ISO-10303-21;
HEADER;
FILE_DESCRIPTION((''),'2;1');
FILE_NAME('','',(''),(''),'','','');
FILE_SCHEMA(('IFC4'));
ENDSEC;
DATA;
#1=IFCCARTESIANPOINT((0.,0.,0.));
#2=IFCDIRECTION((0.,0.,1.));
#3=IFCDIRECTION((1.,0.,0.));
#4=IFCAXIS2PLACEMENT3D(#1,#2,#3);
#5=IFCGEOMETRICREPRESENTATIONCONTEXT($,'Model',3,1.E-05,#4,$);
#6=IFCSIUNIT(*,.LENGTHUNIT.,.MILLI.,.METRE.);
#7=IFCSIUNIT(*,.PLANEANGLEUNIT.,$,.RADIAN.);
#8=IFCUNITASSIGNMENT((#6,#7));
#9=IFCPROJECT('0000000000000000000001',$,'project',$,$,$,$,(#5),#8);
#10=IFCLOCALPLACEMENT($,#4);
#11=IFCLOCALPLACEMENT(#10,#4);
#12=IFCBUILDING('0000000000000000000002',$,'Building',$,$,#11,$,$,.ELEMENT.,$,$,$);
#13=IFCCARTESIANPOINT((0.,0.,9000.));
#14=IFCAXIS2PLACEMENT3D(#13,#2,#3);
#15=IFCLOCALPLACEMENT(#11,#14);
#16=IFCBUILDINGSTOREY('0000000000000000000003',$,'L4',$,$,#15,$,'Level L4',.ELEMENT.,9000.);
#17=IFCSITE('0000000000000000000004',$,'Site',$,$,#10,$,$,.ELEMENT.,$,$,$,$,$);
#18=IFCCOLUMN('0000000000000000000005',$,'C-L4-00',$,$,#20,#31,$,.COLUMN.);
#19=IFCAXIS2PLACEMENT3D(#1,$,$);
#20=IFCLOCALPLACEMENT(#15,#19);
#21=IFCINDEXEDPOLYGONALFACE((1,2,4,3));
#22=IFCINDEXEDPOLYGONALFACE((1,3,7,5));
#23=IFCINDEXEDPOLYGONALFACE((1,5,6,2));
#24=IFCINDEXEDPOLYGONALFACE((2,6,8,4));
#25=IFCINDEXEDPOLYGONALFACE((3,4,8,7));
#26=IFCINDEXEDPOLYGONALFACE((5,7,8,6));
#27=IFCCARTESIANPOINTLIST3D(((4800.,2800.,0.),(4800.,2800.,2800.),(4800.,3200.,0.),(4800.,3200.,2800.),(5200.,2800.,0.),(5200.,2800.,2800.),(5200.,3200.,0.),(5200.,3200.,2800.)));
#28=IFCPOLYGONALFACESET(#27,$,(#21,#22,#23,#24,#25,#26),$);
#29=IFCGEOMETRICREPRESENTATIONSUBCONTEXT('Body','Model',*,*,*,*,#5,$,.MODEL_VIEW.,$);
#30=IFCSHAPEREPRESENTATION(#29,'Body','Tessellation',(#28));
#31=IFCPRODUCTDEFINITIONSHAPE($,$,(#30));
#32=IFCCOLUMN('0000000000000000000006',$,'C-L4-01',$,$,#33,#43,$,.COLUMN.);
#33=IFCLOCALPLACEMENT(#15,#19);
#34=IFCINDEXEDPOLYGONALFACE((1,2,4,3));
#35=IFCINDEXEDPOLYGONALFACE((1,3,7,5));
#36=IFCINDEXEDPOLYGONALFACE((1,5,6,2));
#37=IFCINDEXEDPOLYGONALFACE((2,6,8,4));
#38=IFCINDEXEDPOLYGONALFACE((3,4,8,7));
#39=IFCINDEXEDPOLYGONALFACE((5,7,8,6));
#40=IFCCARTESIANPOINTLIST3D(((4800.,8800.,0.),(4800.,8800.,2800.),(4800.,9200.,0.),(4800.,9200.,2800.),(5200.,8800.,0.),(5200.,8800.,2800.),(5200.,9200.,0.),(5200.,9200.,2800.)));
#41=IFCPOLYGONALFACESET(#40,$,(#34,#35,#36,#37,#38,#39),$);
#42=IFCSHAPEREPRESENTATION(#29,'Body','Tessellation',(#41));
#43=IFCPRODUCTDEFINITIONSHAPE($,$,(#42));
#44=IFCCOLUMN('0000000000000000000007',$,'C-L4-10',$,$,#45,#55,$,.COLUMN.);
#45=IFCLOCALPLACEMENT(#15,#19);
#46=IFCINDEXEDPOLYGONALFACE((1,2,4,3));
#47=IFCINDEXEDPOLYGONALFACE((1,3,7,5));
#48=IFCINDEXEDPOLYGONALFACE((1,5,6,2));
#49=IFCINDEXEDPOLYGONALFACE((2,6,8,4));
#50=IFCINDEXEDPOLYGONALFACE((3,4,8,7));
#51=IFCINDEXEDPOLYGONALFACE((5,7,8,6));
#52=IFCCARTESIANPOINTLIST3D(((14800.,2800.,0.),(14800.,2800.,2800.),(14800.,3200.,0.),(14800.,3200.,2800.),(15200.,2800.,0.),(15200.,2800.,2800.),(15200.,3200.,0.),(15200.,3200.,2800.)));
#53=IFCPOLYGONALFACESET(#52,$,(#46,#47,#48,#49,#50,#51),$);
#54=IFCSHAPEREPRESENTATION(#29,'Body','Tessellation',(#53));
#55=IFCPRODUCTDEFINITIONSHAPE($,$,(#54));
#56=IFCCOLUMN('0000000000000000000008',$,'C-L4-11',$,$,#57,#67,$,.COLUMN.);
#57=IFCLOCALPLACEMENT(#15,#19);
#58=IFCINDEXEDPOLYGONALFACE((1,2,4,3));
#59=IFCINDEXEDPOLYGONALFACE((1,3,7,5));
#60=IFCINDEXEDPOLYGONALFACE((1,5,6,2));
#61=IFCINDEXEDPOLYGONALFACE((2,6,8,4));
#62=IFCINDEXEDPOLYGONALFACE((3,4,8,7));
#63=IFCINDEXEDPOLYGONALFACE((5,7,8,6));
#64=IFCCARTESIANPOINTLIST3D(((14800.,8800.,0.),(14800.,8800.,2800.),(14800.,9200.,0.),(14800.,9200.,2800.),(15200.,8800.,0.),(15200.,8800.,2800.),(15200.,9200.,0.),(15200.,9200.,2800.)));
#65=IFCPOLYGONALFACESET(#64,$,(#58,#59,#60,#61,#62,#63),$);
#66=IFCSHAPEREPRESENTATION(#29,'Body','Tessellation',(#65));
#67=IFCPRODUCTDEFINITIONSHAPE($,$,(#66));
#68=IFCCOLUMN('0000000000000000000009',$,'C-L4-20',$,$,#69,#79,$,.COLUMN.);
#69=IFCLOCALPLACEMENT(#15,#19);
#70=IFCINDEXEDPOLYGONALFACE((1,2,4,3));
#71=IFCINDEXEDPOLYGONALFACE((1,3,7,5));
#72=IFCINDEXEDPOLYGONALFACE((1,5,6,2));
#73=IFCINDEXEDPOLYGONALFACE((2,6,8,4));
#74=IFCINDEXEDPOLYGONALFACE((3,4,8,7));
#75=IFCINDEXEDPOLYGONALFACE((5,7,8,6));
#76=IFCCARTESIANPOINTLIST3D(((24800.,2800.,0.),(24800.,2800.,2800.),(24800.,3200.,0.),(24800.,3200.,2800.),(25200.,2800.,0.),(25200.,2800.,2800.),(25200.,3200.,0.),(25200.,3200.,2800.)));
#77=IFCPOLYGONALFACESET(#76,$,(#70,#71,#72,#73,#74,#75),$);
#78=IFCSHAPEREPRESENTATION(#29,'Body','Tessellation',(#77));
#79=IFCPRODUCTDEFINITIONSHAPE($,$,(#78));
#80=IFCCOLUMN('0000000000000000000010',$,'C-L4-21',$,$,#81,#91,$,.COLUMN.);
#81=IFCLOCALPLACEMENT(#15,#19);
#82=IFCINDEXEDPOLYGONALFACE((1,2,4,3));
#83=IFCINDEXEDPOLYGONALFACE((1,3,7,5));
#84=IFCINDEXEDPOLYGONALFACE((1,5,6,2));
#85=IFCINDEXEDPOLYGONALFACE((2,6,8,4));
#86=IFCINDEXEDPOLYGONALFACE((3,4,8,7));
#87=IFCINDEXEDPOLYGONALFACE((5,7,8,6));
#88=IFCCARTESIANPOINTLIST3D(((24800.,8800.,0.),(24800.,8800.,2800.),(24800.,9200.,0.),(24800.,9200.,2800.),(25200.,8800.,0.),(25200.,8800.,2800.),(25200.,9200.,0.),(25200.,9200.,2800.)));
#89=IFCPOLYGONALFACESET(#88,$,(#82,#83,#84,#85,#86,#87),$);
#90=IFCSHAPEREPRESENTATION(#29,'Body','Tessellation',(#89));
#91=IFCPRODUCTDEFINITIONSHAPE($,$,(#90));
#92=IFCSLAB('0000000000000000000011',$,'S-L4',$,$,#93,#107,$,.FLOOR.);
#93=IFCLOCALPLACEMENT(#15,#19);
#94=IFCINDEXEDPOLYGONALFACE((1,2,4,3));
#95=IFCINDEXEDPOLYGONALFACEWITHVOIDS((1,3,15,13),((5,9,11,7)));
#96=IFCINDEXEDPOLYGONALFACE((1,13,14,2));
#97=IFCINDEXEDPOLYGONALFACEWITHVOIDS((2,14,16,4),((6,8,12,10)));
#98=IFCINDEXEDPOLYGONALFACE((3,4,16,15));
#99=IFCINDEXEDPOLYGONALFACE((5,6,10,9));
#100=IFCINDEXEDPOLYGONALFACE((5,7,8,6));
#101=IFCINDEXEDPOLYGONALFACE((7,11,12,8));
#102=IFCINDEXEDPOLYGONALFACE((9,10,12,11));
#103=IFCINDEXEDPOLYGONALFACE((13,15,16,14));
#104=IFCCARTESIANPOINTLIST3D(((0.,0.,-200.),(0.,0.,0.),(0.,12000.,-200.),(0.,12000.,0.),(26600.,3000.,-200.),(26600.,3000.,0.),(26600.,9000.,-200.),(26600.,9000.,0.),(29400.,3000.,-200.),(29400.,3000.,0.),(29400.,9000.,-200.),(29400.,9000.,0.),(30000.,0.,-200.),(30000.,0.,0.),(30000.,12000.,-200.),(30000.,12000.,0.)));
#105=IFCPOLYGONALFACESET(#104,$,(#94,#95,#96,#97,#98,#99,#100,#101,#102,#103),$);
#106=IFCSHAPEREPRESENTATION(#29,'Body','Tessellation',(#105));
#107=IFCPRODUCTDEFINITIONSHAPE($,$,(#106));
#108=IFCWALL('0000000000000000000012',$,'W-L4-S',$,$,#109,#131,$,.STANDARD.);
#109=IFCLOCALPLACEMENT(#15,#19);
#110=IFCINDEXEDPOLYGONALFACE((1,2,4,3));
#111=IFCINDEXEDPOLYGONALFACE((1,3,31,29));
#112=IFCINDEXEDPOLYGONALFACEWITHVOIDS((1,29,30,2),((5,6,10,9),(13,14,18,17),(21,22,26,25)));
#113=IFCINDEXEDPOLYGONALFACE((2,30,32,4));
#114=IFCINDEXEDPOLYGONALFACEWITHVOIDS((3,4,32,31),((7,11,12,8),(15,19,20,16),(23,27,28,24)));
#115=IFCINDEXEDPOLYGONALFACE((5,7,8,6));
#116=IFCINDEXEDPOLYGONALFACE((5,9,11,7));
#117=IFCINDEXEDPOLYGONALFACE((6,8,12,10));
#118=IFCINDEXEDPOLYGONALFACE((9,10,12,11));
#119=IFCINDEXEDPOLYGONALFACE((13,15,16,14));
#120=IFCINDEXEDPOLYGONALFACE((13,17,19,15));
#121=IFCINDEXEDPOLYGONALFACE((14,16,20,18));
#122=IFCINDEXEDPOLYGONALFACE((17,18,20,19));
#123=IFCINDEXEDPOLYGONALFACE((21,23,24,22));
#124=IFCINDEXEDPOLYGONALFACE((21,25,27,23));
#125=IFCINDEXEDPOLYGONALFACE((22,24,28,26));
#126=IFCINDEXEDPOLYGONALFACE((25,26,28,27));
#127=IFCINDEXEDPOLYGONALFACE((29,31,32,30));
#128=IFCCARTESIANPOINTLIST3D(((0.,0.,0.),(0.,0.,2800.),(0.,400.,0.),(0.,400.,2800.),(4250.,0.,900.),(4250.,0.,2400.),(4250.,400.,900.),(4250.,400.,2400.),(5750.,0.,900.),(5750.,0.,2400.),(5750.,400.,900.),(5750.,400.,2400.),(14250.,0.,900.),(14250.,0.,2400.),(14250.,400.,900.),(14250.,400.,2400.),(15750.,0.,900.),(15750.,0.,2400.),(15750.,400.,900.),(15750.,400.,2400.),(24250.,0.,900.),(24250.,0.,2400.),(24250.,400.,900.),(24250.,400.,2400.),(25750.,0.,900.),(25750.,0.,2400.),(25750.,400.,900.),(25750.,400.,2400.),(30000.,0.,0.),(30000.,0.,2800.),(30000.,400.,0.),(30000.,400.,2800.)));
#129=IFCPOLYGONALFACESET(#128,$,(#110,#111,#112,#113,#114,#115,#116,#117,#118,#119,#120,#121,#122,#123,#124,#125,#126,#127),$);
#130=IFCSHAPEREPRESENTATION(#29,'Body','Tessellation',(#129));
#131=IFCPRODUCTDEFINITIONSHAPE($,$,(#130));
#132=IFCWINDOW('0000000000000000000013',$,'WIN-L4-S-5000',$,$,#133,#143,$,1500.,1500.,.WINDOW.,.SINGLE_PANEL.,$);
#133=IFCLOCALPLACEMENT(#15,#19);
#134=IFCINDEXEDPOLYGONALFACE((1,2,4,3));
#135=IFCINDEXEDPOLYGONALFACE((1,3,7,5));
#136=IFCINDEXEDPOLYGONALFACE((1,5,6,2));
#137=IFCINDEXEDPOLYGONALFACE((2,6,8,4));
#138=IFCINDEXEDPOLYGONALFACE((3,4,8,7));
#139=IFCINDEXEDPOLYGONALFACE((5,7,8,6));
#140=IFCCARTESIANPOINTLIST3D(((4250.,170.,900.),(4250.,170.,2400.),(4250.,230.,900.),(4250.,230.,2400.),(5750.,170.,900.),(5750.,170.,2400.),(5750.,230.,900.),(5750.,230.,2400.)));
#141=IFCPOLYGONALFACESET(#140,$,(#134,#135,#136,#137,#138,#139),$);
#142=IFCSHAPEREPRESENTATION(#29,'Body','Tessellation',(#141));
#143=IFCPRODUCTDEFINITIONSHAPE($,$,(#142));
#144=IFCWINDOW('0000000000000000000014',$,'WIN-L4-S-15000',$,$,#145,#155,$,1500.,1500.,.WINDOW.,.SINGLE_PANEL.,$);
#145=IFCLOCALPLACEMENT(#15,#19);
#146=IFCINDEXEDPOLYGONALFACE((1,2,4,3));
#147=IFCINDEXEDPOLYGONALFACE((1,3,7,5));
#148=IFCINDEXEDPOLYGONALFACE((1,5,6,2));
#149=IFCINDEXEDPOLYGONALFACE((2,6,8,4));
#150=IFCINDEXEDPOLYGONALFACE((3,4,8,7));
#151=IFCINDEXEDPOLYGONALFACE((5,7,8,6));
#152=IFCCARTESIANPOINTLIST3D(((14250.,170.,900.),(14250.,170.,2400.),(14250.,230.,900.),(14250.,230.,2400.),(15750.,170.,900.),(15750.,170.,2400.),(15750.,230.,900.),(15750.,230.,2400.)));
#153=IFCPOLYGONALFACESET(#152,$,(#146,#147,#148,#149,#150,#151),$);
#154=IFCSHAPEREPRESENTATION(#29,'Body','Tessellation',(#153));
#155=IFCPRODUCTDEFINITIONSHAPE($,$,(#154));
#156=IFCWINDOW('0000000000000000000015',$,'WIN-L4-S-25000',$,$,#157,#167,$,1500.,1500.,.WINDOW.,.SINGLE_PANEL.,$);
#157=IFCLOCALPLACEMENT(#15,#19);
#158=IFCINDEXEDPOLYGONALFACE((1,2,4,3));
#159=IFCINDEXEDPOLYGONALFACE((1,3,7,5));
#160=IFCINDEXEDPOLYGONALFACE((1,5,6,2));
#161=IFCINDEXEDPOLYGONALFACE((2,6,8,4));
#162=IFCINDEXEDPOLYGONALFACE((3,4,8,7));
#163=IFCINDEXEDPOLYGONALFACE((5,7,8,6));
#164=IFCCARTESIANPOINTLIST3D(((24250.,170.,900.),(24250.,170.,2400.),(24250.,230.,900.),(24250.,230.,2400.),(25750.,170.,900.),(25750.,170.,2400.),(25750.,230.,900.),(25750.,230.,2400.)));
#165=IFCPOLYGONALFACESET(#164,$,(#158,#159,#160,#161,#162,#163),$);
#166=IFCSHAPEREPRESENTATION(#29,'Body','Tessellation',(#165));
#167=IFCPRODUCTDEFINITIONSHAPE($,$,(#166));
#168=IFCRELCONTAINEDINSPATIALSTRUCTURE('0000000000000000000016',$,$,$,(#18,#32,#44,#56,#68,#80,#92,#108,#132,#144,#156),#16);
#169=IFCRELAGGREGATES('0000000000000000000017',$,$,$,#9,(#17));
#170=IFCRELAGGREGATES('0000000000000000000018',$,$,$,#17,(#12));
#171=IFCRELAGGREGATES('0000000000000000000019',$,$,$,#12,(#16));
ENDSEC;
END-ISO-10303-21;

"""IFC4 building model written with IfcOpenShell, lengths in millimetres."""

from ifc_helpers import new_model, si_unit, frame, origin_with_axes, origin_2d, place, context, subcontext, project, spatial, rectangle, extrude, element, fill, save


model = new_model("IFC4")

# Units and contexts
model_context = context("Model", 3, precision=1e-05, world=origin_with_axes())
body_context = subcontext(model_context, "Body", "Model", "MODEL_VIEW")
ifc_project = project(units=[si_unit("LENGTHUNIT", "METRE", prefix="MILLI"), si_unit("PLANEANGLEUNIT", "RADIAN")], contexts=[model_context])

# Site, building, storey
site_placement = place(None, origin_with_axes())
site = spatial("IfcSite", under=ifc_project, at=site_placement, Name="Site", CompositionType="ELEMENT")
building_placement = place(site_placement, origin_with_axes())
building = spatial("IfcBuilding", under=site, at=building_placement, Name="Building", CompositionType="ELEMENT")
storey_placement = place(building_placement, frame((0.0, 0.0, 9000.0), z_axis=(0.0, 0.0, 1.0), x_axis=(1.0, 0.0, 0.0)))
storey = spatial("IfcBuildingStorey", under=building, at=storey_placement, Name="L4", LongName="Level L4", CompositionType="ELEMENT", Elevation=9000.0)

# Columns
for number, where, z_axis, x_axis, name in (
    (1, (5000.0, 3000.0, 0.0), (0.0, 0.0, 1.0), (1.0, 0.0, 0.0), "C-L4-00"),
    (2, (5000.0, 9000.0, 0.0), (0.0, 0.0, 1.0), (1.0, 0.0, 0.0), "C-L4-01"),
    (3, (15000.0, 3000.0, 0.0), (0.0, 0.0, 1.0), (1.0, 0.0, 0.0), "C-L4-10"),
    (4, (15000.0, 9000.0, 0.0), (0.0, 0.0, 1.0), (1.0, 0.0, 0.0), "C-L4-11"),
    (5, (25000.0, 3000.0, 0.0), (0.0, 0.0, 1.0), (1.0, 0.0, 0.0), "C-L4-20"),
    (6, (25000.0, 9000.0, 0.0), (0.0, 0.0, 1.0), (1.0, 0.0, 0.0), "C-L4-21"),
):
    element("IfcColumn", number, at=place(storey_placement, frame(where, z_axis=z_axis, x_axis=x_axis)), inside=storey, Name=name, PredefinedType="COLUMN", context=body_context, shape_type="SweptSolid", body=[
        extrude(rectangle(XDim=400.0, YDim=400.0, at=origin_2d()), origin_with_axes(), (0.0, 0.0, 1.0), 2800.0),
    ])

# Slab, opening
slab_placement = place(storey_placement, frame((15000.0, 6000.0, -200.0), z_axis=(0.0, 0.0, 1.0), x_axis=(1.0, 0.0, 0.0)))
slab = element("IfcSlab", 7, at=slab_placement, inside=storey, Name="S-L4", PredefinedType="FLOOR", context=body_context, shape_type="SweptSolid", body=[
    extrude(rectangle(XDim=30000.0, YDim=12000.0, at=origin_2d()), origin_with_axes(), (0.0, 0.0, 1.0), 200.0),
])
opening_1_placement = place(slab_placement, frame((13000.0, 0.0, -50.0), z_axis=(0.0, 0.0, 1.0), x_axis=(1.0, 0.0, 0.0)))
element("IfcOpeningElement", 8, at=opening_1_placement, cuts=slab, PredefinedType="OPENING", context=body_context, shape_type="SweptSolid", body=[
    extrude(rectangle(XDim=2800.0, YDim=6000.0, at=origin_2d()), origin_with_axes(), (0.0, 0.0, 1.0), 300.0),
])

# Wall, openings, windows
wall_1_placement = place(storey_placement, frame((15000.0, 200.0, 0.0), z_axis=(0.0, 0.0, 1.0), x_axis=(1.0, 0.0, 0.0)))
wall_1 = element("IfcWall", 9, at=wall_1_placement, inside=storey, Name="W-L4-S", PredefinedType="STANDARD", context=body_context, shape_type="SweptSolid", body=[
    extrude(rectangle(XDim=30000.0, YDim=400.0, at=origin_2d()), origin_with_axes(), (0.0, 0.0, 1.0), 2800.0),
])
opening_2_placement = place(wall_1_placement, frame((-10000.0, 0.0, 900.0), z_axis=(0.0, 0.0, 1.0), x_axis=(1.0, 0.0, 0.0)))
opening_2 = element("IfcOpeningElement", 10, at=opening_2_placement, cuts=wall_1, PredefinedType="OPENING", context=body_context, shape_type="SweptSolid", body=[
    extrude(rectangle(XDim=1500.0, YDim=500.0, at=origin_2d()), origin_with_axes(), (0.0, 0.0, 1.0), 1500.0),
])
opening_3_placement = place(wall_1_placement, frame((0.0, 0.0, 900.0), z_axis=(0.0, 0.0, 1.0), x_axis=(1.0, 0.0, 0.0)))
opening_3 = element("IfcOpeningElement", 11, at=opening_3_placement, cuts=wall_1, PredefinedType="OPENING", context=body_context, shape_type="SweptSolid", body=[
    extrude(rectangle(XDim=1500.0, YDim=500.0, at=origin_2d()), origin_with_axes(), (0.0, 0.0, 1.0), 1500.0),
])
opening_4_placement = place(wall_1_placement, frame((10000.0, 0.0, 900.0), z_axis=(0.0, 0.0, 1.0), x_axis=(1.0, 0.0, 0.0)))
opening_4 = element("IfcOpeningElement", 12, at=opening_4_placement, cuts=wall_1, PredefinedType="OPENING", context=body_context, shape_type="SweptSolid", body=[
    extrude(rectangle(XDim=1500.0, YDim=500.0, at=origin_2d()), origin_with_axes(), (0.0, 0.0, 1.0), 1500.0),
])
window_1_placement = place(wall_1_placement, frame((-10000.0, 0.0, 900.0), z_axis=(0.0, 0.0, 1.0), x_axis=(1.0, 0.0, 0.0)))
window_1 = element("IfcWindow", 13, at=window_1_placement, inside=storey, Name="WIN-L4-S-5000", OverallHeight=1500.0, OverallWidth=1500.0, PartitioningType="SINGLE_PANEL", PredefinedType="WINDOW", context=body_context, shape_type="SweptSolid", body=[
    extrude(rectangle(XDim=1500.0, YDim=60.0, at=origin_2d()), origin_with_axes(), (0.0, 0.0, 1.0), 1500.0),
])
fill(opening_2, window_1)
window_2_placement = place(wall_1_placement, frame((0.0, 0.0, 900.0), z_axis=(0.0, 0.0, 1.0), x_axis=(1.0, 0.0, 0.0)))
window_2 = element("IfcWindow", 14, at=window_2_placement, inside=storey, Name="WIN-L4-S-15000", OverallHeight=1500.0, OverallWidth=1500.0, PartitioningType="SINGLE_PANEL", PredefinedType="WINDOW", context=body_context, shape_type="SweptSolid", body=[
    extrude(rectangle(XDim=1500.0, YDim=60.0, at=origin_2d()), origin_with_axes(), (0.0, 0.0, 1.0), 1500.0),
])
fill(opening_3, window_2)
window_3_placement = place(wall_1_placement, frame((10000.0, 0.0, 900.0), z_axis=(0.0, 0.0, 1.0), x_axis=(1.0, 0.0, 0.0)))
window_3 = element("IfcWindow", 15, at=window_3_placement, inside=storey, Name="WIN-L4-S-25000", OverallHeight=1500.0, OverallWidth=1500.0, PartitioningType="SINGLE_PANEL", PredefinedType="WINDOW", context=body_context, shape_type="SweptSolid", body=[
    extrude(rectangle(XDim=1500.0, YDim=60.0, at=origin_2d()), origin_with_axes(), (0.0, 0.0, 1.0), 1500.0),
])
fill(opening_4, window_3)

save(model, "model.ifc")
